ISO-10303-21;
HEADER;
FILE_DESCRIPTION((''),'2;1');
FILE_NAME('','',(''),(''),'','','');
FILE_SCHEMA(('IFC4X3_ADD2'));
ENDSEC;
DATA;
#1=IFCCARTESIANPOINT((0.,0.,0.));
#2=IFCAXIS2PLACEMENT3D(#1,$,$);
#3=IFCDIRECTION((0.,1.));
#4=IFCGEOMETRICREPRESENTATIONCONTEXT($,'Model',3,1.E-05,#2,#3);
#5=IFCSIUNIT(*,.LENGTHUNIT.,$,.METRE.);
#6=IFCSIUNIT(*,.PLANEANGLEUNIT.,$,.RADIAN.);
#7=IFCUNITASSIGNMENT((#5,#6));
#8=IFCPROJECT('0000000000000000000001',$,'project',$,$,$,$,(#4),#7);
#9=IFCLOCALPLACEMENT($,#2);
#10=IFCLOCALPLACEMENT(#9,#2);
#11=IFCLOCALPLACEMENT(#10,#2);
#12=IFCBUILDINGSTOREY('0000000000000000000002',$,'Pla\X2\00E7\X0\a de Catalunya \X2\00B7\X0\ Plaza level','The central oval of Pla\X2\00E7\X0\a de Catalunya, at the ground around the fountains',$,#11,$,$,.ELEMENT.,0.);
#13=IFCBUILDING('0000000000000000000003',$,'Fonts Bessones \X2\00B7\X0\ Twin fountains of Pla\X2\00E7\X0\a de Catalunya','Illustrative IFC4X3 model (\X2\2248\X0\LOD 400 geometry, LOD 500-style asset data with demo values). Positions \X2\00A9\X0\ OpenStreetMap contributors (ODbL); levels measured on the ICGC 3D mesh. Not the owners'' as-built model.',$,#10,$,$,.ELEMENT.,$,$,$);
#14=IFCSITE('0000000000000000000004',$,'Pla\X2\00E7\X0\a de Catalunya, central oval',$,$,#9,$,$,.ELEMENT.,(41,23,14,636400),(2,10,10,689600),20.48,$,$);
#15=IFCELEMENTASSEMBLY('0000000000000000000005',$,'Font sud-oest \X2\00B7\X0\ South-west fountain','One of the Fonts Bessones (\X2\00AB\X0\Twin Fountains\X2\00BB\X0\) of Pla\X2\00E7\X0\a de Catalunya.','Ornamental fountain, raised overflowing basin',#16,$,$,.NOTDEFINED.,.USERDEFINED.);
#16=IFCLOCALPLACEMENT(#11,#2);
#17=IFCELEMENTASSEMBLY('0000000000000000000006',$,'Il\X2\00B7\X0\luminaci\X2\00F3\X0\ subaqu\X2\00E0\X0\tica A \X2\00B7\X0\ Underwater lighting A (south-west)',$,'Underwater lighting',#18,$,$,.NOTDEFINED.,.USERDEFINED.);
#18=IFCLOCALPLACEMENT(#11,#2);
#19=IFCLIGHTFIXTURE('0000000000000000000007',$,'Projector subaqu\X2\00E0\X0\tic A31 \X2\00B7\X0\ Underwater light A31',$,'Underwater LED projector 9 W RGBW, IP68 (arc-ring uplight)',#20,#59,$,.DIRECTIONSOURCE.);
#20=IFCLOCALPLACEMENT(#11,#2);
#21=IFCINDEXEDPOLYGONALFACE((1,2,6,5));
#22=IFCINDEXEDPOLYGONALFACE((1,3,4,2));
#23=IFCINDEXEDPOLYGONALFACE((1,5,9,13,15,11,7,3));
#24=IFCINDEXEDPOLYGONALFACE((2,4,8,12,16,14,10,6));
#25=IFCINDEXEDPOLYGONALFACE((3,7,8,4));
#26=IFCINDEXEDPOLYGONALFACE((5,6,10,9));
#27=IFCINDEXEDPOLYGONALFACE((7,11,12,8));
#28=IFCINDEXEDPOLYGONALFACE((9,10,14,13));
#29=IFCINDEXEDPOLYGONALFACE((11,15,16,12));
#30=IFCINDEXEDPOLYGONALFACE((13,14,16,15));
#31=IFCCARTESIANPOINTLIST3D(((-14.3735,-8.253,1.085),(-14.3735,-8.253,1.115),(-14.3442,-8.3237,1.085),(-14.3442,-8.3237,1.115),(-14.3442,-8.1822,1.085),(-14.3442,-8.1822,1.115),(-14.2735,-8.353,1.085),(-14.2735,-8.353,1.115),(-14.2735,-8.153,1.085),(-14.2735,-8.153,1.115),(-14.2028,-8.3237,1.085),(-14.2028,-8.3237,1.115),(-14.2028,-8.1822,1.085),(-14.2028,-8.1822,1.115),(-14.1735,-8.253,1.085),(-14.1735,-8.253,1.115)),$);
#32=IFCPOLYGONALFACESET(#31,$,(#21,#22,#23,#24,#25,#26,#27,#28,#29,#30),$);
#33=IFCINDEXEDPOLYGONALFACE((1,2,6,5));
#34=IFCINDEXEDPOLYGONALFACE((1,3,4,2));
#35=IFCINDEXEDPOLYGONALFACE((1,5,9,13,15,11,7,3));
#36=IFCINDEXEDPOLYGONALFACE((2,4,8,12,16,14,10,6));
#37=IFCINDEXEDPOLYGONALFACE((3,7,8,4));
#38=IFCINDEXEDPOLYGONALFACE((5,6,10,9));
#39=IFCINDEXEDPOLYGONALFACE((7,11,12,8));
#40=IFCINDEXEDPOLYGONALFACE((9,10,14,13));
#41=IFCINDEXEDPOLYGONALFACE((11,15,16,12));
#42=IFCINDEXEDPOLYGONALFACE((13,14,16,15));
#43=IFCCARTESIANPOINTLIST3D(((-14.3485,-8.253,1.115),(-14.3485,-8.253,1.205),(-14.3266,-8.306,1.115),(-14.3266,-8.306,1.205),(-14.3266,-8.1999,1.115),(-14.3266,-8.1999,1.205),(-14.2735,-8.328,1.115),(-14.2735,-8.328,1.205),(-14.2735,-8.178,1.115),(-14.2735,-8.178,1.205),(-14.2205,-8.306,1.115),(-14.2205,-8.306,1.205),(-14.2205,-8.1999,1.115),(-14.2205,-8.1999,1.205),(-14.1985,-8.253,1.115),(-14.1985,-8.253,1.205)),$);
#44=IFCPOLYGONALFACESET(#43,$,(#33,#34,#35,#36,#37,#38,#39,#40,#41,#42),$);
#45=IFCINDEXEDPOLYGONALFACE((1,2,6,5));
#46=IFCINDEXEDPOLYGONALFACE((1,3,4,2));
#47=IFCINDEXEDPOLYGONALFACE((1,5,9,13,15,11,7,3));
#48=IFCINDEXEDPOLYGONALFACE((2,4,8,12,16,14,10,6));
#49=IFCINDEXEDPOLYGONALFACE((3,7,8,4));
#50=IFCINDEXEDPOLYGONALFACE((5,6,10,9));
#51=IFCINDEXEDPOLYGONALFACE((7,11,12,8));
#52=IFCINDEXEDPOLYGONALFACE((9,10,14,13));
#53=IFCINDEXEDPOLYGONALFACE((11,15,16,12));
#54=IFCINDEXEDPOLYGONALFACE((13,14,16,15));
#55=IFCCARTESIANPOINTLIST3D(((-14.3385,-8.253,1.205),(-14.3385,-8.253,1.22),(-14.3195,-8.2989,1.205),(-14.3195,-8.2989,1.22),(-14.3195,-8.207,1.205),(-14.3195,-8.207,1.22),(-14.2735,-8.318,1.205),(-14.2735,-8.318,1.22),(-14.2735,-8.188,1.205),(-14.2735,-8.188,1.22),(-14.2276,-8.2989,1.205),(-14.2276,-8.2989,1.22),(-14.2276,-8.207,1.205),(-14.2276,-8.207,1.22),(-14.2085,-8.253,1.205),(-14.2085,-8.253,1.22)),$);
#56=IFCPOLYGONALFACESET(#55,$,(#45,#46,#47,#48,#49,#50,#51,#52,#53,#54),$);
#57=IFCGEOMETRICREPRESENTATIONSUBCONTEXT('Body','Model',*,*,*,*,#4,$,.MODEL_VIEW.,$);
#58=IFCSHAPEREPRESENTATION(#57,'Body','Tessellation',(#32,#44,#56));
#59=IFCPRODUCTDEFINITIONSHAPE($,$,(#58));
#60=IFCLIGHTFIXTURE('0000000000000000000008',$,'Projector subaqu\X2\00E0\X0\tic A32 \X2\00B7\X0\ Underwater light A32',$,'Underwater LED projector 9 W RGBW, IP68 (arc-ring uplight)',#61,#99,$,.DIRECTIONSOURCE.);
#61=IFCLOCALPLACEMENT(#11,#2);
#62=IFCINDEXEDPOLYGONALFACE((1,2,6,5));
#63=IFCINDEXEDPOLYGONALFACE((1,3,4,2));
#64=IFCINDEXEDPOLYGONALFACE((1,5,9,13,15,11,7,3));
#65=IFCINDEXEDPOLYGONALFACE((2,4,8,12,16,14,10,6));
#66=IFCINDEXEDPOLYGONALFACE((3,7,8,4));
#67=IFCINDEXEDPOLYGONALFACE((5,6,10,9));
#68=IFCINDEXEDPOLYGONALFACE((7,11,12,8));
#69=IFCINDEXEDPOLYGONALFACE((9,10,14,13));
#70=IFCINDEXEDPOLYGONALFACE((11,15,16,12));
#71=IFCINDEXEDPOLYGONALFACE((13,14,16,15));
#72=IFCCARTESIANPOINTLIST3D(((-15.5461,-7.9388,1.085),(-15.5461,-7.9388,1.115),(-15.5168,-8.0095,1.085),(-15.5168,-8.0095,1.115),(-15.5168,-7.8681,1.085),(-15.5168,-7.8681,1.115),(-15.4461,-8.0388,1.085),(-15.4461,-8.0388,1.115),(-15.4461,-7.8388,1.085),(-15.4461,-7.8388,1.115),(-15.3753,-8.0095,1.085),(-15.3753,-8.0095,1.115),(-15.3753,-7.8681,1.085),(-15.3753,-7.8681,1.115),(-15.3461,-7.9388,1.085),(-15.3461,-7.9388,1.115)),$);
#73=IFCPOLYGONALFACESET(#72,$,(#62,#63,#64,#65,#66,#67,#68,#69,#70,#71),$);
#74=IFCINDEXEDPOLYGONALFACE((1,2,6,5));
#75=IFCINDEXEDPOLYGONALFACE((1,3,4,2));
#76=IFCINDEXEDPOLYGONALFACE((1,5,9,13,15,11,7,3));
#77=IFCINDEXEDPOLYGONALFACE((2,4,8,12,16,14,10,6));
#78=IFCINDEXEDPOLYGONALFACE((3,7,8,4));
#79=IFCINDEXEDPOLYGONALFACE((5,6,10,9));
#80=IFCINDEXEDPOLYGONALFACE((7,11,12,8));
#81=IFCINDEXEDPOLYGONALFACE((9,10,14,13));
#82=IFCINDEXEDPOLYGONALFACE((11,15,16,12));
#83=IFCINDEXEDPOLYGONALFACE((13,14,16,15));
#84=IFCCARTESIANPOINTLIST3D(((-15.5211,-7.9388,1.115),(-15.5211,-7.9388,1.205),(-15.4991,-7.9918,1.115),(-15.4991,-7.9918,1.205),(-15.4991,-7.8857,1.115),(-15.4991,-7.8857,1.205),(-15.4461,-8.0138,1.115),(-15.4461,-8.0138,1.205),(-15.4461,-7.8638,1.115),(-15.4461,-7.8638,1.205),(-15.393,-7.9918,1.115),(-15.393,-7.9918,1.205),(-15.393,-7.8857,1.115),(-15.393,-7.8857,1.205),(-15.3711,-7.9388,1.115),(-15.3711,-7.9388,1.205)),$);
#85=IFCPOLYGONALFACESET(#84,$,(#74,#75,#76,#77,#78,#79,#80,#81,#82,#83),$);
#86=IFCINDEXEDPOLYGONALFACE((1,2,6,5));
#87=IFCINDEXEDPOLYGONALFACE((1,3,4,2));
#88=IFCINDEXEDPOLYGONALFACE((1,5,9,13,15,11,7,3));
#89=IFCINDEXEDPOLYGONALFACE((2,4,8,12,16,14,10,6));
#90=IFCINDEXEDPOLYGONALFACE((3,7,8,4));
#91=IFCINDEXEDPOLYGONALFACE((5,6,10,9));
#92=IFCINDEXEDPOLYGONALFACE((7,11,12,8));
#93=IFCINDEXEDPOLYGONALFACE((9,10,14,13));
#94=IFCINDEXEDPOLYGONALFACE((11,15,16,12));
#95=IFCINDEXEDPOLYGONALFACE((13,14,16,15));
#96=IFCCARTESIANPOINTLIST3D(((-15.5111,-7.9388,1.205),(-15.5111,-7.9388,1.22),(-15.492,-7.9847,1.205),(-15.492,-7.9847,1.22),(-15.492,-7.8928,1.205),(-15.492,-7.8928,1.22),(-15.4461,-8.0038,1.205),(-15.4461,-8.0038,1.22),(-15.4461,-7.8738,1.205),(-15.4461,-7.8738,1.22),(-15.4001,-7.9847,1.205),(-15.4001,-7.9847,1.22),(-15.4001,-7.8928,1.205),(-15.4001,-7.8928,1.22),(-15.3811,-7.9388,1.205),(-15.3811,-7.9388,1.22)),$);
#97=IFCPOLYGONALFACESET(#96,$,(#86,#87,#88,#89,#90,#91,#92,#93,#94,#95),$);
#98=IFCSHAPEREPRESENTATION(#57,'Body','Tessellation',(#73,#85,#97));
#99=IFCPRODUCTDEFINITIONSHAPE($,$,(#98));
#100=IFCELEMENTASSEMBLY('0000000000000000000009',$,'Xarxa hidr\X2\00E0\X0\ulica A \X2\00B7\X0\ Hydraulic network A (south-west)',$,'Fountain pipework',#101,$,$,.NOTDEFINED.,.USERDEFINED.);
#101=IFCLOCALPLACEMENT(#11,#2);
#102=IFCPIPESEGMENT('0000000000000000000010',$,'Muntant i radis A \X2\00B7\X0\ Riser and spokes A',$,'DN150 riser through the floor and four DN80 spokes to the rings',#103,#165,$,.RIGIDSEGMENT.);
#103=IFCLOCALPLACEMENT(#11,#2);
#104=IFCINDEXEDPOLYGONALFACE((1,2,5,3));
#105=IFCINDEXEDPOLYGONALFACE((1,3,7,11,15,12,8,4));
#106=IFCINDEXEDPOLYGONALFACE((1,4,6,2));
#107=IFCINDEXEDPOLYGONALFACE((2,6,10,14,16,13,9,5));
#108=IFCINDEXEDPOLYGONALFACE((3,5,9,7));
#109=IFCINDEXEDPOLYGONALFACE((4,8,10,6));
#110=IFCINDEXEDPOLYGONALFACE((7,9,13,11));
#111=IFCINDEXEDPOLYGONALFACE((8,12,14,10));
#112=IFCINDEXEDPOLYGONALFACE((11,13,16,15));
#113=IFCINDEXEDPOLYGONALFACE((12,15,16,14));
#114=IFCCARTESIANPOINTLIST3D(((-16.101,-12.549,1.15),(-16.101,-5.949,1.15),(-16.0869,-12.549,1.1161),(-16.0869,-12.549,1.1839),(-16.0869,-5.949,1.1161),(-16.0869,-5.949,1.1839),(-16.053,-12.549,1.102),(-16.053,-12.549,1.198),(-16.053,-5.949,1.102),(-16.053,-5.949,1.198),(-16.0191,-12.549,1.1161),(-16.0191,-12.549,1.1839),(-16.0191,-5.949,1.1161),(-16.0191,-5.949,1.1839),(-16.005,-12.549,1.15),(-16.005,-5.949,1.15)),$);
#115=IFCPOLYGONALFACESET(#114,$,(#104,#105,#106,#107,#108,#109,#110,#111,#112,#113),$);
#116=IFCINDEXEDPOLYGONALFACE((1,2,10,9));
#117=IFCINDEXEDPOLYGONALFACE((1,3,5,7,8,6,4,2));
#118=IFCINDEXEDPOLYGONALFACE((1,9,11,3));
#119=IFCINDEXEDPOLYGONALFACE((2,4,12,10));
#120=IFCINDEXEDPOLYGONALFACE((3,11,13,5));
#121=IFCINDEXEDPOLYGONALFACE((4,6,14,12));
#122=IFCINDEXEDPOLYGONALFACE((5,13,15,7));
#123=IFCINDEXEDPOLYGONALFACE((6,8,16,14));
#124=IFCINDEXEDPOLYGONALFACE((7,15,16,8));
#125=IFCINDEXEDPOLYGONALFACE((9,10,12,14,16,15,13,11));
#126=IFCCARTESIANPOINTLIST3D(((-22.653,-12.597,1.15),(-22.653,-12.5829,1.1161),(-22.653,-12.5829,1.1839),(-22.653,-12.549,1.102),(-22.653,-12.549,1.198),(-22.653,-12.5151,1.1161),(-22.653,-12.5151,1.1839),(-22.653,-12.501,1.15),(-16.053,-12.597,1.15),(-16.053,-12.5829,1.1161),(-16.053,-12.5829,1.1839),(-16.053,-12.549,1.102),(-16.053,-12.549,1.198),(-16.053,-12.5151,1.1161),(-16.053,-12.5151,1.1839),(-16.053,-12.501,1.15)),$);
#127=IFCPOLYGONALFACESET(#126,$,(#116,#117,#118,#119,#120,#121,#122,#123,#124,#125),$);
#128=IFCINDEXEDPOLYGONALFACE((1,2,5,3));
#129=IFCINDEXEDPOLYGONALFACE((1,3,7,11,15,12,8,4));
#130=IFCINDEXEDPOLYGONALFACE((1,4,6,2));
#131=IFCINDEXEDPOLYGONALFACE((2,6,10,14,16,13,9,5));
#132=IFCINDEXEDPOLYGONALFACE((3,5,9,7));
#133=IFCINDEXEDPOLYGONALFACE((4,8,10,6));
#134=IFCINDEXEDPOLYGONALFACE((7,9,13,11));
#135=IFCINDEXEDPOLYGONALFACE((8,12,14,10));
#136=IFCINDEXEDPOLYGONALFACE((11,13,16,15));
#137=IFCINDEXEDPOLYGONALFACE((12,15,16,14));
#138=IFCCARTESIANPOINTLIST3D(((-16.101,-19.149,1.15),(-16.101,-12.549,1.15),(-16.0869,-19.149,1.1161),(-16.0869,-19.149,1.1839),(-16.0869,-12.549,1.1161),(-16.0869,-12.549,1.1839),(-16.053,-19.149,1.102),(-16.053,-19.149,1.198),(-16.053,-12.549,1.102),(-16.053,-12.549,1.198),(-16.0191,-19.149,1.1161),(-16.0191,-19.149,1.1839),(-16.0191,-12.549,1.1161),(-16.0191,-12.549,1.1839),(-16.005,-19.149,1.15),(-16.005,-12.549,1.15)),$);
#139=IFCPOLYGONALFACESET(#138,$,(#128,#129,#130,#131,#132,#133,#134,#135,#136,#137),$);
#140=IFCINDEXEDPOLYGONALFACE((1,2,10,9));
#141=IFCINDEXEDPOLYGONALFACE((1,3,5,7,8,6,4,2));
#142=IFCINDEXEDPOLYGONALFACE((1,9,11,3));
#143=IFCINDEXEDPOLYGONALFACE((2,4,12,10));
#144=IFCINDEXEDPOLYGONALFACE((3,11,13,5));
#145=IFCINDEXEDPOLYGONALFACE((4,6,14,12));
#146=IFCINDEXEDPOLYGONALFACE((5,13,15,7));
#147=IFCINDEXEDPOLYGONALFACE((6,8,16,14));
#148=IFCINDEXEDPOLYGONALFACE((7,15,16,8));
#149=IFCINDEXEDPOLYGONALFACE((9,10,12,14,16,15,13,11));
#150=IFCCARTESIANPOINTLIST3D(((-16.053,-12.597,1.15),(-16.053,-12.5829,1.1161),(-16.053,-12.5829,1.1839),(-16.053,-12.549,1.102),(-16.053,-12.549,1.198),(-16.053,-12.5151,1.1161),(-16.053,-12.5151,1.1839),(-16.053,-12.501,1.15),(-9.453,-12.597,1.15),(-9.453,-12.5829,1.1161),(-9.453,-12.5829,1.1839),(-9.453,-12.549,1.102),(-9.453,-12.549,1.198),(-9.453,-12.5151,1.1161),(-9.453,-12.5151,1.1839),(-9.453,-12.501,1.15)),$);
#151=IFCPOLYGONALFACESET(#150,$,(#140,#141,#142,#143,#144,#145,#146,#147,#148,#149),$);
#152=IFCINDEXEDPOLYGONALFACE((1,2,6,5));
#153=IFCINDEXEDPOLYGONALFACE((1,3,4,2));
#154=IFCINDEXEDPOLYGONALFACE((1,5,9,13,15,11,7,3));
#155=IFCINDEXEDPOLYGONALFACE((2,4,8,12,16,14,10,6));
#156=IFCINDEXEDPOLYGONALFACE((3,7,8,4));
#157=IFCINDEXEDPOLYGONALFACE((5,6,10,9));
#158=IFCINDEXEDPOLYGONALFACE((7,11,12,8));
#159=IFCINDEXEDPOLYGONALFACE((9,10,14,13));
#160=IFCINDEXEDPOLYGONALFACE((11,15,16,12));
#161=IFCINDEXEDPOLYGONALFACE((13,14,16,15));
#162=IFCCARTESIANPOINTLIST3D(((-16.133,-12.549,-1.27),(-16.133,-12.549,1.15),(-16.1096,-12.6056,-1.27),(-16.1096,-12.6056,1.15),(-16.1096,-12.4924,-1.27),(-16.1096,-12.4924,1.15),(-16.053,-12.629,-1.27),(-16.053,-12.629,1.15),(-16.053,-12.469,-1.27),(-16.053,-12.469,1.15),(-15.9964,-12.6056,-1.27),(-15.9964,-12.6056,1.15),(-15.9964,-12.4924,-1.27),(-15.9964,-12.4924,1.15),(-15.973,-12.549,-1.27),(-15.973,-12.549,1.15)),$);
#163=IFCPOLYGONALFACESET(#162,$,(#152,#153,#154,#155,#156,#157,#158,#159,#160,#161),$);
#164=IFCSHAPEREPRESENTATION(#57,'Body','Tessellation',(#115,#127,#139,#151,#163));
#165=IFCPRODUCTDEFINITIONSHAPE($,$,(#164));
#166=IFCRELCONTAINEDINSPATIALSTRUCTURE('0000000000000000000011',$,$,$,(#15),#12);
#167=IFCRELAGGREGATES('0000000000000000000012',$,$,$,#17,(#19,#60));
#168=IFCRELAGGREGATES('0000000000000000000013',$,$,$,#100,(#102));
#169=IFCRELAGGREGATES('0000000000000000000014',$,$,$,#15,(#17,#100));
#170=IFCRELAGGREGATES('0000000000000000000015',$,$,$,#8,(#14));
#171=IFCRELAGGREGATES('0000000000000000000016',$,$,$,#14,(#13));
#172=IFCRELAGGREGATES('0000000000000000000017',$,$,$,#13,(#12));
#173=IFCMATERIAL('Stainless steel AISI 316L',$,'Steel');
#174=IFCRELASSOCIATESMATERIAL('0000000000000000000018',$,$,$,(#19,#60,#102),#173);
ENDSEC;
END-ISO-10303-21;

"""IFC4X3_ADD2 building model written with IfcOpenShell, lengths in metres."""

from ifc_helpers import new_model, si_unit, direction, frame, origin, place, context, subcontext, project, spatial, polyline, outline, extrude, material, element, aggregate, save


model = new_model("IFC4X3_ADD2")

# Units and contexts
model_context = context("Model", 3, precision=1e-05, world=origin(), true_north=direction((0.0, 1.0)))
body_context = subcontext(model_context, "Body", "Model", "MODEL_VIEW")
ifc_project = project(units=[si_unit("LENGTHUNIT", "METRE"), si_unit("PLANEANGLEUNIT", "RADIAN")], contexts=[model_context])

# Site, building, storey
site_placement = place(None, origin())
site = spatial("IfcSite", under=ifc_project, at=site_placement, Name="Plaça de Catalunya, central oval", CompositionType="ELEMENT", RefLatitude=(41, 23, 14, 636400), RefLongitude=(2, 10, 10, 689600), RefElevation=20.48)
building_placement = place(site_placement, origin())
building = spatial("IfcBuilding", under=site, at=building_placement, Name="Fonts Bessones · Twin fountains of Plaça de Catalunya", Description="Illustrative IFC4X3 model (≈LOD 400 geometry, LOD 500-style asset data with demo values). Positions © OpenStreetMap contributors (ODbL); levels measured on the ICGC 3D mesh. Not the owners' as-built model.", CompositionType="ELEMENT")
storey_placement = place(building_placement, origin())
storey = spatial("IfcBuildingStorey", under=building, at=storey_placement, Name="Plaça de Catalunya · Plaza level", Description="The central oval of Plaça de Catalunya, at the ground around the fountains", CompositionType="ELEMENT", Elevation=0.0)

# Element assembly
assembly_1_placement = place(building_placement, origin())
assembly_1 = element("IfcElementAssembly", 1, at=assembly_1_placement, inside=storey, Name="Font sud-oest · South-west fountain", Description="One of the Fonts Bessones («Twin Fountains») of Plaça de Catalunya.", ObjectType="Ornamental fountain, raised overflowing basin", AssemblyPlace="NOTDEFINED", PredefinedType="USERDEFINED")

# Element assembly, light fixtures
assembly_2_placement = place(building_placement, origin())
assembly_2 = element("IfcElementAssembly", 2, at=assembly_2_placement, Name="Il·luminació subaquàtica A · Underwater lighting A (south-west)", ObjectType="Underwater lighting", AssemblyPlace="NOTDEFINED", PredefinedType="USERDEFINED")
ifc_material_1 = material(Name="Stainless steel AISI 316L", Category="Steel")
light_fixture_1_placement = place(building_placement, origin())
light_fixture_1 = element("IfcLightFixture", 3, at=light_fixture_1_placement, material=ifc_material_1, Name="Projector subaquàtic A31 · Underwater light A31", ObjectType="Underwater LED projector 9 W RGBW, IP68 (arc-ring uplight)", PredefinedType="DIRECTIONSOURCE", context=body_context, shape_type="SweptSolid", body=[
    extrude(outline(polyline([(-14.1735, -8.253), (-14.2028, -8.1822), (-14.2735, -8.153), (-14.3442, -8.1822), (-14.3735, -8.253), (-14.3442, -8.3237), (-14.2735, -8.353), (-14.2028, -8.3237), (-14.1735, -8.253)])), frame((0.0, 0.0, 1.085)), (0.0, 0.0, 1.0), 0.03),
    extrude(outline(polyline([(-14.1985, -8.253), (-14.2205, -8.1999), (-14.2735, -8.178), (-14.3266, -8.1999), (-14.3485, -8.253), (-14.3266, -8.306), (-14.2735, -8.328), (-14.2205, -8.306), (-14.1985, -8.253)])), frame((0.0, 0.0, 1.115)), (0.0, 0.0, 1.0), 0.09),
    extrude(outline(polyline([(-14.2085, -8.253), (-14.2276, -8.207), (-14.2735, -8.188), (-14.3195, -8.207), (-14.3385, -8.253), (-14.3195, -8.2989), (-14.2735, -8.318), (-14.2276, -8.2989), (-14.2085, -8.253)])), frame((0.0, 0.0, 1.205)), (0.0, 0.0, 1.0), 0.015),
])
light_fixture_2_placement = place(building_placement, origin())
light_fixture_2 = element("IfcLightFixture", 4, at=light_fixture_2_placement, material=ifc_material_1, Name="Projector subaquàtic A32 · Underwater light A32", ObjectType="Underwater LED projector 9 W RGBW, IP68 (arc-ring uplight)", PredefinedType="DIRECTIONSOURCE", context=body_context, shape_type="SweptSolid", body=[
    extrude(outline(polyline([(-15.3461, -7.9388), (-15.3753, -7.8681), (-15.4461, -7.8388), (-15.5168, -7.8681), (-15.5461, -7.9388), (-15.5168, -8.0095), (-15.4461, -8.0388), (-15.3753, -8.0095), (-15.3461, -7.9388)])), frame((0.0, 0.0, 1.085)), (0.0, 0.0, 1.0), 0.03),
    extrude(outline(polyline([(-15.3711, -7.9388), (-15.393, -7.8857), (-15.4461, -7.8638), (-15.4991, -7.8857), (-15.5211, -7.9388), (-15.4991, -7.9918), (-15.4461, -8.0138), (-15.393, -7.9918), (-15.3711, -7.9388)])), frame((0.0, 0.0, 1.115)), (0.0, 0.0, 1.0), 0.09),
    extrude(outline(polyline([(-15.3811, -7.9388), (-15.4001, -7.8928), (-15.4461, -7.8738), (-15.492, -7.8928), (-15.5111, -7.9388), (-15.492, -7.9847), (-15.4461, -8.0038), (-15.4001, -7.9847), (-15.3811, -7.9388)])), frame((0.0, 0.0, 1.205)), (0.0, 0.0, 1.0), 0.015),
])
aggregate(assembly_2, [light_fixture_1, light_fixture_2])

# Element assembly, pipe segment
assembly_3_placement = place(building_placement, origin())
assembly_3 = element("IfcElementAssembly", 5, at=assembly_3_placement, Name="Xarxa hidràulica A · Hydraulic network A (south-west)", ObjectType="Fountain pipework", AssemblyPlace="NOTDEFINED", PredefinedType="USERDEFINED")
pipe_segment_1_placement = place(building_placement, origin())
pipe_segment_1 = element("IfcPipeSegment", 6, at=pipe_segment_1_placement, material=ifc_material_1, Name="Muntant i radis A · Riser and spokes A", ObjectType="DN150 riser through the floor and four DN80 spokes to the rings", PredefinedType="RIGIDSEGMENT", context=body_context, shape_type="SweptSolid", body=[
    extrude(outline(polyline([(0.048, 0.0), (0.0339, 0.0339), (0.0, 0.048), (-0.0339, 0.0339), (-0.048, 0.0), (-0.0339, -0.0339), (0.0, -0.048), (0.0339, -0.0339), (0.048, 0.0)])), frame((-16.053, -12.549, 1.15), z_axis=(0.0, 1.0, 0.0), x_axis=(1.0, 0.0, 0.0)), (0.0, 0.0, 1.0), 6.6),
    extrude(outline(polyline([(0.048, 0.0), (0.0339, 0.0339), (0.0, 0.048), (-0.0339, 0.0339), (-0.048, 0.0), (-0.0339, -0.0339), (0.0, -0.048), (0.0339, -0.0339), (0.048, 0.0)])), frame((-16.053, -12.549, 1.15), z_axis=(-1.0, 0.0, 0.0), x_axis=(0.0, 1.0, 0.0)), (0.0, 0.0, 1.0), 6.6),
    extrude(outline(polyline([(0.048, 0.0), (0.0339, 0.0339), (0.0, 0.048), (-0.0339, 0.0339), (-0.048, 0.0), (-0.0339, -0.0339), (0.0, -0.048), (0.0339, -0.0339), (0.048, 0.0)])), frame((-16.053, -12.549, 1.15), z_axis=(0.0, -1.0, 0.0), x_axis=(-1.0, 0.0, 0.0)), (0.0, 0.0, 1.0), 6.6),
    extrude(outline(polyline([(0.048, 0.0), (0.0339, 0.0339), (0.0, 0.048), (-0.0339, 0.0339), (-0.048, 0.0), (-0.0339, -0.0339), (0.0, -0.048), (0.0339, -0.0339), (0.048, 0.0)])), frame((-16.053, -12.549, 1.15), z_axis=(1.0, 0.0, 0.0), x_axis=(0.0, -1.0, 0.0)), (0.0, 0.0, 1.0), 6.6),
    extrude(outline(polyline([(0.08, 0.0), (0.0566, 0.0566), (0.0, 0.08), (-0.0566, 0.0566), (-0.08, 0.0), (-0.0566, -0.0566), (0.0, -0.08), (0.0566, -0.0566), (0.08, 0.0)])), frame((-16.053, -12.549, -1.27), z_axis=(0.0, 0.0, 1.0), x_axis=(0.0, 1.0, 0.0)), (0.0, 0.0, 1.0), 2.42),
])

aggregate(assembly_3, [pipe_segment_1])

aggregate(assembly_1, [assembly_2, assembly_3])

save(model, "model.ifc")
